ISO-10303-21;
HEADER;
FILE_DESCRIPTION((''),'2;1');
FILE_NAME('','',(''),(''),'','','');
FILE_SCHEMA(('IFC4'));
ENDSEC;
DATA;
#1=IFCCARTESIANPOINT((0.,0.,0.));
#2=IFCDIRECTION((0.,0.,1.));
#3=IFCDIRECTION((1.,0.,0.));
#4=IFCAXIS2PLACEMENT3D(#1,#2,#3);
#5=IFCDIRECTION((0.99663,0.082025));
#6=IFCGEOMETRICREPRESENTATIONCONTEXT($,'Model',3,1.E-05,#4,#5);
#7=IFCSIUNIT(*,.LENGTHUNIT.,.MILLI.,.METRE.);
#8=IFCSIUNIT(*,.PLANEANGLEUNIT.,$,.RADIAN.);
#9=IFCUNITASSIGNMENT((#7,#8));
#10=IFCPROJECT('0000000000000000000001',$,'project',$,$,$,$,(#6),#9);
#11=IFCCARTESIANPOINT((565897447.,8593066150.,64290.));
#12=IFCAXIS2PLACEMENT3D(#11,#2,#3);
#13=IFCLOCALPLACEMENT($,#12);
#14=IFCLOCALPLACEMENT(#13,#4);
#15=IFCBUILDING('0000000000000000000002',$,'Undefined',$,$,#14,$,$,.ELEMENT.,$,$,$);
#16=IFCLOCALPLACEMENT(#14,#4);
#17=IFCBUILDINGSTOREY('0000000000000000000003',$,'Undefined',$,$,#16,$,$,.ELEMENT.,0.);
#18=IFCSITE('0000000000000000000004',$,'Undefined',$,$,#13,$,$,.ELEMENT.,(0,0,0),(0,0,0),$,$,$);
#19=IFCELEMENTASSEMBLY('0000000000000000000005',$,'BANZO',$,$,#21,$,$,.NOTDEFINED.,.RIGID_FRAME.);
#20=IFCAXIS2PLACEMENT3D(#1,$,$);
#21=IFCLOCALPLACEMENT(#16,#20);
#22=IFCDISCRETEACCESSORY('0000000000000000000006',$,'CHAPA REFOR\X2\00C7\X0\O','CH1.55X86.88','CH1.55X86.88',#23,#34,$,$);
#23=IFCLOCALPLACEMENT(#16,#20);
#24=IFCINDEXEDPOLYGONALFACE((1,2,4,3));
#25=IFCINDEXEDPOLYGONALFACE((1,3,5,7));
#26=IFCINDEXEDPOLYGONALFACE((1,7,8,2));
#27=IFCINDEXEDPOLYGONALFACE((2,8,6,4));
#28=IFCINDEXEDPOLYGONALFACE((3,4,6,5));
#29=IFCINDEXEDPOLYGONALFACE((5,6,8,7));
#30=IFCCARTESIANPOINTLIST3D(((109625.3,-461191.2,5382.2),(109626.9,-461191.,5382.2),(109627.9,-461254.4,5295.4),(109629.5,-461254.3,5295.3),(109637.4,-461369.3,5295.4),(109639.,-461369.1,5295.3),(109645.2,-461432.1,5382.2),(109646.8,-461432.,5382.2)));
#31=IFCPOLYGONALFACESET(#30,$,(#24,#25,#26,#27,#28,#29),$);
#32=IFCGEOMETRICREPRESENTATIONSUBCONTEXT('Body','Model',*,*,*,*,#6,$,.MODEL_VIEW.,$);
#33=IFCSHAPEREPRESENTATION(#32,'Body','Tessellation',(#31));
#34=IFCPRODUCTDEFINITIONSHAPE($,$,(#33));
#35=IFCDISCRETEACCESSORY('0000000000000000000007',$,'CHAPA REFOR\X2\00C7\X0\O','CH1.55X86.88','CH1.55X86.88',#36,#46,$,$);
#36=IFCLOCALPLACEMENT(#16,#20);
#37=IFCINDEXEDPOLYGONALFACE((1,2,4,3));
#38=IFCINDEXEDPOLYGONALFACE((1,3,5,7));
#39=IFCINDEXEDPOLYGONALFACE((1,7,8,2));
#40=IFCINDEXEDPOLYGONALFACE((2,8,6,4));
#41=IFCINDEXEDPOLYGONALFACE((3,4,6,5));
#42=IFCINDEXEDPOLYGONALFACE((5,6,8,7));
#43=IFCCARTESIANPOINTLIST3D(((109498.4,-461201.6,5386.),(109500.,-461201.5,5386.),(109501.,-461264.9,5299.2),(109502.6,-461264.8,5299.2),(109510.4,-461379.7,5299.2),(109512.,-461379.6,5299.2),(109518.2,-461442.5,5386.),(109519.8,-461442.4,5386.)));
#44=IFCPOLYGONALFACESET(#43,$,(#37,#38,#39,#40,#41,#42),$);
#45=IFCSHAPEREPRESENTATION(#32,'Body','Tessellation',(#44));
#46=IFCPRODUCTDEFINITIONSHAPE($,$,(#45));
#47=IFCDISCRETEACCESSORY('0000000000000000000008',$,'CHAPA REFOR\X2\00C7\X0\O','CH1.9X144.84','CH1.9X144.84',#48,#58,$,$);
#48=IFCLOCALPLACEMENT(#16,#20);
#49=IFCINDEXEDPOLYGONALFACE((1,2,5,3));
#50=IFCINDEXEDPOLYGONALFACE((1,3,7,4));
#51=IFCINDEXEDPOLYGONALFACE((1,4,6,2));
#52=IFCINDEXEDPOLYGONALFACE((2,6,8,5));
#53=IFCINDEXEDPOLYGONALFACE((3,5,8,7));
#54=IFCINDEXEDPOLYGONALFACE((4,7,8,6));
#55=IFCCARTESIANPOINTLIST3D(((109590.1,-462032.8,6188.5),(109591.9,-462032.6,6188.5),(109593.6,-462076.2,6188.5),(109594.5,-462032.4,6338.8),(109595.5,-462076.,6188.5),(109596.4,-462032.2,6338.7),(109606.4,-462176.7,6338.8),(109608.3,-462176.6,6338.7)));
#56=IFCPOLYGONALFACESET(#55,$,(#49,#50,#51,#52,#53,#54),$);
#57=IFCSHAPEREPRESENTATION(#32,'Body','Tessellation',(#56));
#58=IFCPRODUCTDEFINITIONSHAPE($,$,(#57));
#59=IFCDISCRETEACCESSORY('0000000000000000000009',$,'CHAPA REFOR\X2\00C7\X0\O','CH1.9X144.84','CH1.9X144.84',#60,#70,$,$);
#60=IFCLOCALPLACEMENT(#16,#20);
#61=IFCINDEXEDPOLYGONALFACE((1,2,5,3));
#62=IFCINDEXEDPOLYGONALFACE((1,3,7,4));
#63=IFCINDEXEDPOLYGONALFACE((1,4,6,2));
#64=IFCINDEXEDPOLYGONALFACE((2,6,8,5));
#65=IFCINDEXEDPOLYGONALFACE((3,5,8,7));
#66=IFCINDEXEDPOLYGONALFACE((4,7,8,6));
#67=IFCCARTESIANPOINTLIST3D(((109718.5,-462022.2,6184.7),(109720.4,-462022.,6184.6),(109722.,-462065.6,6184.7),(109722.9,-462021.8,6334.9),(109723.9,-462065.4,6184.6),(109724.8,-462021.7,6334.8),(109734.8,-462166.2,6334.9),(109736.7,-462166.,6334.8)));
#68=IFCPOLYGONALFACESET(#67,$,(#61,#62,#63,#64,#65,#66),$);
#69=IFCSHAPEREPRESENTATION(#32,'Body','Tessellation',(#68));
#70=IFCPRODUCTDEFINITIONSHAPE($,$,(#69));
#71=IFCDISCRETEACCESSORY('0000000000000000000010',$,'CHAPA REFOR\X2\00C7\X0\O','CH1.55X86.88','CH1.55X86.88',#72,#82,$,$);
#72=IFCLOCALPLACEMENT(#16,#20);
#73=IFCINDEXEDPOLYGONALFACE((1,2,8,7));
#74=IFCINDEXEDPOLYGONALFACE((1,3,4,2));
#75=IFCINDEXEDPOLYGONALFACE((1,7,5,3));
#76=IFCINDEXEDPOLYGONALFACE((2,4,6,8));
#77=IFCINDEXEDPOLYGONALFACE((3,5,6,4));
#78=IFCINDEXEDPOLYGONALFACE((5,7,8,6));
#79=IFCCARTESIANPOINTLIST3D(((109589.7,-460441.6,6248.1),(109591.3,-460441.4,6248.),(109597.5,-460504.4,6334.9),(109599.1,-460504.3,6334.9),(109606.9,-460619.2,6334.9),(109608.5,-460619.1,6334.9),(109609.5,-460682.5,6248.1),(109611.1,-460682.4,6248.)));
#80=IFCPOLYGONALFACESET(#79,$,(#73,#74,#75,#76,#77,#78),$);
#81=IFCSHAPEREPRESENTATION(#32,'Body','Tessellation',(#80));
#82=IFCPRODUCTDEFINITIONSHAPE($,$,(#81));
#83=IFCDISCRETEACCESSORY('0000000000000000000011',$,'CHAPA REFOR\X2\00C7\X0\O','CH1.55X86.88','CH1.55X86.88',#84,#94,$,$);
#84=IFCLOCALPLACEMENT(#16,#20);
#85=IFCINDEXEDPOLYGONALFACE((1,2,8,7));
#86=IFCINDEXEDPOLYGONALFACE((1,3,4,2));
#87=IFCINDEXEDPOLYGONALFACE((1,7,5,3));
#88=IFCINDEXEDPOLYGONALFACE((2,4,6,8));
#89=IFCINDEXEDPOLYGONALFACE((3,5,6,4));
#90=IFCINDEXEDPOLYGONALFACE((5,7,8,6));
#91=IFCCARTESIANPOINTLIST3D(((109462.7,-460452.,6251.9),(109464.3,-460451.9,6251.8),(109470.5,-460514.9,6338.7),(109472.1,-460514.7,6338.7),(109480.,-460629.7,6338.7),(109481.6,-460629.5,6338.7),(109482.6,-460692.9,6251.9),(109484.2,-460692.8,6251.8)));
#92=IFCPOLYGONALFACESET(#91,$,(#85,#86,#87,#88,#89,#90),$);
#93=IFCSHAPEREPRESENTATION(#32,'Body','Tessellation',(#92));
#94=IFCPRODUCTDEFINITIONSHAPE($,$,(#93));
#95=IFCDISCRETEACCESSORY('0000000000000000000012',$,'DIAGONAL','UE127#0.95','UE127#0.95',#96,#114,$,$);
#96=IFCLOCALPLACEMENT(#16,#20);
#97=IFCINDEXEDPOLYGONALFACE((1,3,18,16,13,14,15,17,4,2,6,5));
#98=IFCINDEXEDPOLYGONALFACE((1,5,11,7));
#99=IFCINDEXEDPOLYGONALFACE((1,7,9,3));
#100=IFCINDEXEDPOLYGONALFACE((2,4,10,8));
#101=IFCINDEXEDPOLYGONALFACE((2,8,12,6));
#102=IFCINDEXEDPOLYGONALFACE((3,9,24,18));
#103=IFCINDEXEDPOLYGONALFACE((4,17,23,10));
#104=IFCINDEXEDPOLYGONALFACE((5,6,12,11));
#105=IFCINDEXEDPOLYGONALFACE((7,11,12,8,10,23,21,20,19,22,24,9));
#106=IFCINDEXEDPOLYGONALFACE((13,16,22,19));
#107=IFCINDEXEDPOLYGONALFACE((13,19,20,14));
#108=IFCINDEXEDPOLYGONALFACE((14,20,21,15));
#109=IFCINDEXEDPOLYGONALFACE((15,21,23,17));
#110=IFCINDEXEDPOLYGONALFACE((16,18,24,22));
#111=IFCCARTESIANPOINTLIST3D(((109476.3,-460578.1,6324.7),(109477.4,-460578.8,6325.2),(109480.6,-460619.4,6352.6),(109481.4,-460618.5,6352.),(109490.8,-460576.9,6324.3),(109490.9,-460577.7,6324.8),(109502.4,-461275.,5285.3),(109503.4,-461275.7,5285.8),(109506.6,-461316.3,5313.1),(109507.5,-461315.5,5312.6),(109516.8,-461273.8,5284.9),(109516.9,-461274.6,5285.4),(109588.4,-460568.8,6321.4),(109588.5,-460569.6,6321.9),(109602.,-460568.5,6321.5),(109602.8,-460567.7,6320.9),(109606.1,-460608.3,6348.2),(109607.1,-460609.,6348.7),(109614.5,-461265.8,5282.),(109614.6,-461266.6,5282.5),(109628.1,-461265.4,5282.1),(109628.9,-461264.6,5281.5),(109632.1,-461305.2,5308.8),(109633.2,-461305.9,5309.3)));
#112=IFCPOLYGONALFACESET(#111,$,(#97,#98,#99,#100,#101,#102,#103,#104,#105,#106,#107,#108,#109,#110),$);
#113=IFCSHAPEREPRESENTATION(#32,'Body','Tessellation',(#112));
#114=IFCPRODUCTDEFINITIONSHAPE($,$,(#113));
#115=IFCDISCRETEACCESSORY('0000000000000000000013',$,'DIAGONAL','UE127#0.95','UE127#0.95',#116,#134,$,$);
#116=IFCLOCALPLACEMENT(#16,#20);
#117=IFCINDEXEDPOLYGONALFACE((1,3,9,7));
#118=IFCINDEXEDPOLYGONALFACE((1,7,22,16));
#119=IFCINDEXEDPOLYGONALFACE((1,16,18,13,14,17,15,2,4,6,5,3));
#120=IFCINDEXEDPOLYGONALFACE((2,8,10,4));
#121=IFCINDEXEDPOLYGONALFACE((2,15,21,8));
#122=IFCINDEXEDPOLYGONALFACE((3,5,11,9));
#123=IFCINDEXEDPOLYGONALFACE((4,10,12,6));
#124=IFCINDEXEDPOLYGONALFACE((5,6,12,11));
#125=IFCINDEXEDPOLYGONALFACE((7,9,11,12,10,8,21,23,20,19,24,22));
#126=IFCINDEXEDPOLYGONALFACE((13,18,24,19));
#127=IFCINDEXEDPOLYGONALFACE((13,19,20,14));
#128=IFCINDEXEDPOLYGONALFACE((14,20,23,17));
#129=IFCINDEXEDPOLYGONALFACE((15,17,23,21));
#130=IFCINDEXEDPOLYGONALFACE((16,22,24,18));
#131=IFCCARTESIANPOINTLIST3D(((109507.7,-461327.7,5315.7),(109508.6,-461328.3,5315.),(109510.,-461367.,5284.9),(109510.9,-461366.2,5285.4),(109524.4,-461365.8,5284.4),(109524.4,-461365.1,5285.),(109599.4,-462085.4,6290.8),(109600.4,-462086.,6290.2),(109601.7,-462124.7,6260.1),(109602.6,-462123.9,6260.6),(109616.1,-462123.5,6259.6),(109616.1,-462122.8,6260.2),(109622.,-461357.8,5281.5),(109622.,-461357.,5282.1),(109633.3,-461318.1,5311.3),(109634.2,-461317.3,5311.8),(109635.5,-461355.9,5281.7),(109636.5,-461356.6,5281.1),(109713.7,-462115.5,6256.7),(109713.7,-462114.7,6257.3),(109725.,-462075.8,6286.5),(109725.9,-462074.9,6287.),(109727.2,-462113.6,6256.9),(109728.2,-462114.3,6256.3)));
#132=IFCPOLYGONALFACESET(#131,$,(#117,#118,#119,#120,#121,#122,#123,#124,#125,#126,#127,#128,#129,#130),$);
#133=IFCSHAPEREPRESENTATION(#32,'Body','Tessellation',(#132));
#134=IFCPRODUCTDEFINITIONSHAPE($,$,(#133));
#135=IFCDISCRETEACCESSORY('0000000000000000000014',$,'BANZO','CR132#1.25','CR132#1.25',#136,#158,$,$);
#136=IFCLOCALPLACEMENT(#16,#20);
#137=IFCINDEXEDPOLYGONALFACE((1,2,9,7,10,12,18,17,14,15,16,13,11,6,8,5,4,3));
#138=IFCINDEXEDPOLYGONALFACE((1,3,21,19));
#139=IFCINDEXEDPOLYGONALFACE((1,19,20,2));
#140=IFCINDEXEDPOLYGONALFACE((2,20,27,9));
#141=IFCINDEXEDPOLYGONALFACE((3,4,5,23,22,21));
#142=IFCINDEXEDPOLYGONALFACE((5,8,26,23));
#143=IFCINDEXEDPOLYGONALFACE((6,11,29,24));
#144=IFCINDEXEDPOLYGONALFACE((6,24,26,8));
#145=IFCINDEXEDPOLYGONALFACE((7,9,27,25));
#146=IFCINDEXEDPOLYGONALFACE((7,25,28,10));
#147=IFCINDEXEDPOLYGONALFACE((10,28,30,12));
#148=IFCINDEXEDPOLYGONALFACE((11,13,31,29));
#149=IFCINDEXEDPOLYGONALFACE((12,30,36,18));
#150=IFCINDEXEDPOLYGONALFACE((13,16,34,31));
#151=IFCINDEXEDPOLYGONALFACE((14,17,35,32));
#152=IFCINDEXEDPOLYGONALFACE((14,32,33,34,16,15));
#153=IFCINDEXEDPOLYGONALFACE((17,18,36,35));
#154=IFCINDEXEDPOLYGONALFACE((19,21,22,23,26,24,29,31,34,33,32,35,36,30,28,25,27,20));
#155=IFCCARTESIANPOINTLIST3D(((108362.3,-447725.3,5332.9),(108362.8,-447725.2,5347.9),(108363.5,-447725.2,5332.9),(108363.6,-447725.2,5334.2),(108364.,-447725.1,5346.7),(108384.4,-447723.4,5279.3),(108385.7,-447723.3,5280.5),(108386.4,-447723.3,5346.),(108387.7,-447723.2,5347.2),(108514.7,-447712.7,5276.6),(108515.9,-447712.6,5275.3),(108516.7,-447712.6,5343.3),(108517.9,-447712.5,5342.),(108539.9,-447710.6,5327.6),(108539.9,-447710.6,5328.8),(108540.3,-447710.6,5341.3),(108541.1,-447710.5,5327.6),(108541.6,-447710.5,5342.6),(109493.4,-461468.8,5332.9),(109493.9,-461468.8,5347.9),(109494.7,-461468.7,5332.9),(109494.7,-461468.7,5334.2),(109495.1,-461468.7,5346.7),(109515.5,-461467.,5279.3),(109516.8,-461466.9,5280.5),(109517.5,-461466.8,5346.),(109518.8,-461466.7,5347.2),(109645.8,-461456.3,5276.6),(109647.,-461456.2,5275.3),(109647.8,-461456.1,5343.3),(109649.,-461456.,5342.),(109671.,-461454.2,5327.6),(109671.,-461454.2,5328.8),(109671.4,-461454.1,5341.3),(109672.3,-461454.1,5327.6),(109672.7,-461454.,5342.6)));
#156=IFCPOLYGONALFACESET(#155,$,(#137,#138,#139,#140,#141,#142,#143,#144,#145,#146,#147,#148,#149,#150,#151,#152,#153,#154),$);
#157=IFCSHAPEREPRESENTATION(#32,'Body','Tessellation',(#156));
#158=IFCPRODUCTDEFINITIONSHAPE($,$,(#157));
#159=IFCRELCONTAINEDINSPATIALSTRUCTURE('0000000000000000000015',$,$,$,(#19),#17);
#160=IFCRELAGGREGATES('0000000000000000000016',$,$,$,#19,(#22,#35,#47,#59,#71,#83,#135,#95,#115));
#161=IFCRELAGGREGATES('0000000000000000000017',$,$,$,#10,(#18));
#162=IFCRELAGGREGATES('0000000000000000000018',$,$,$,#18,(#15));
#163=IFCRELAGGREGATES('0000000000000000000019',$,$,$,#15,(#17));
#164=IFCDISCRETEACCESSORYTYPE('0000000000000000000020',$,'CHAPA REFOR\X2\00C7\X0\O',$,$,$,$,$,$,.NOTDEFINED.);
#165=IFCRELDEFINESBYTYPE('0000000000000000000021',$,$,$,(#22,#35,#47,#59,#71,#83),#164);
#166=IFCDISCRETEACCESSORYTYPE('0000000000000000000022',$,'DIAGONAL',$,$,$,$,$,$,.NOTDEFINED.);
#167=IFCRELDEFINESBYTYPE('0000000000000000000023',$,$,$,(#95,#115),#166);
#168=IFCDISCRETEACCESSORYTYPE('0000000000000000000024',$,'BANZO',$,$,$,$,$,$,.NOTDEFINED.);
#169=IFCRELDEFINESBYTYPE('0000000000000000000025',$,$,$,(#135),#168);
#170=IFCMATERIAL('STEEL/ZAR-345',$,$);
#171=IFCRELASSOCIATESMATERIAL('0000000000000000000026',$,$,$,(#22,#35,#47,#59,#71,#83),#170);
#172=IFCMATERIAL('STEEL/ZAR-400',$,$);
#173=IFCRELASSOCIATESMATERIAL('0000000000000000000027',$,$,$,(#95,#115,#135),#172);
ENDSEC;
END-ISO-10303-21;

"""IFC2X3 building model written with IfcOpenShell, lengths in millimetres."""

from ifc_helpers import new_model, si_unit, direction, frame, frame_2d, origin_with_axes, place, context, subcontext, project, spatial, polyline, c_section, outline, extrude, material, type_object, element, aggregate, save


model = new_model("IFC2X3")

# Units and contexts
model_context = context("Model", 3, precision=1e-05, world=origin_with_axes(), true_north=direction((0.99663, 0.082025)))
body_context = subcontext(model_context, "Body", "Model", "MODEL_VIEW")
ifc_project = project(units=[si_unit("LENGTHUNIT", "METRE", prefix="MILLI"), si_unit("PLANEANGLEUNIT", "RADIAN")], contexts=[model_context])

# Site, building, storey
site_placement = place(None, frame((565897447.0, 8593066150.0, 64290.0), z_axis=(0.0, 0.0, 1.0), x_axis=(1.0, 0.0, 0.0)))
site = spatial("IfcSite", under=ifc_project, at=site_placement, Name="Undefined", CompositionType="ELEMENT", RefLatitude=(0, 0, 0), RefLongitude=(0, 0, 0))
building_placement = place(site_placement, origin_with_axes())
building = spatial("IfcBuilding", under=site, at=building_placement, Name="Undefined", CompositionType="ELEMENT")
storey_placement = place(building_placement, origin_with_axes())
storey = spatial("IfcBuildingStorey", under=building, at=storey_placement, Name="Undefined", CompositionType="ELEMENT", Elevation=0.0)

# Shared definitions
ifc_material_1 = material(Name="STEEL/ZAR-400")

# Element assembly, discrete accessories
assembly_1_placement = place(storey_placement, origin_with_axes())
assembly_1 = element("IfcElementAssembly", 1, at=assembly_1_placement, inside=storey, Name="BANZO", AssemblyPlace="NOTDEFINED", PredefinedType="RIGID_FRAME")
ifc_material_2 = material(Name="STEEL/ZAR-345")
discrete_accessory_type_1 = type_object("IfcDiscreteAccessoryType", Name="CHAPA REFORÇO")
discrete_accessory_1_placement = place(assembly_1_placement, frame((109626.1, -461191.1, 5382.2), z_axis=(0.996182, 0.081989, -0.029987), x_axis=(0.082025, -0.99663, 0.0)))
discrete_accessory_1 = element("IfcDiscreteAccessory", 2, at=discrete_accessory_1_placement, type_object=discrete_accessory_type_1, material=ifc_material_2, Name="CHAPA REFORÇO", Description="CH1.55X86.88", ObjectType="CH1.55X86.88", context=body_context, shape_type="SweptSolid", body=[
    extrude(outline(polyline([(0.0, 0.0), (241.7, 0.0), (178.5, 86.9), (63.3, 86.9), (0.0, 0.0)])), frame((0.0, 0.0, -0.8), z_axis=(0.0, 0.0, 1.0), x_axis=(1.0, 0.0, 0.0)), (0.0, 0.0, 1.0), 1.6),
])
discrete_accessory_2_placement = place(assembly_1_placement, frame((109499.2, -461201.6, 5386.0), z_axis=(0.996182, 0.081989, -0.029987), x_axis=(0.082025, -0.99663, 0.0)))
discrete_accessory_2 = element("IfcDiscreteAccessory", 3, at=discrete_accessory_2_placement, type_object=discrete_accessory_type_1, material=ifc_material_2, Name="CHAPA REFORÇO", Description="CH1.55X86.88", ObjectType="CH1.55X86.88", context=body_context, shape_type="SweptSolid", body=[
    extrude(outline(polyline([(0.0, 0.0), (241.7, 0.0), (178.5, 86.9), (63.3, 86.9), (0.0, 0.0)])), frame((0.0, 0.0, -0.8), z_axis=(0.0, 0.0, 1.0), x_axis=(1.0, 0.0, 0.0)), (0.0, 0.0, 1.0), 1.6),
])
discrete_accessory_3_placement = place(assembly_1_placement, frame((109595.5, -462032.3, 6338.7), z_axis=(0.996182, 0.081989, -0.029987), x_axis=(0.082025, -0.99663, 0.0)))
discrete_accessory_3 = element("IfcDiscreteAccessory", 4, at=discrete_accessory_3_placement, type_object=discrete_accessory_type_1, material=ifc_material_2, Name="CHAPA REFORÇO", Description="CH1.9X144.84", ObjectType="CH1.9X144.84", context=body_context, shape_type="SweptSolid", body=[
    extrude(outline(polyline([(0.0, 0.0), (144.8, 0.0), (43.5, 150.3), (0.0, 150.3), (0.0, 0.0)])), frame((0.0, 0.0, -0.9), z_axis=(0.0, 0.0, 1.0), x_axis=(1.0, 0.0, 0.0)), (0.0, 0.0, 1.0), 1.9),
])
discrete_accessory_4_placement = place(assembly_1_placement, frame((109723.9, -462021.8, 6334.9), z_axis=(0.996182, 0.081989, -0.029987), x_axis=(0.082025, -0.99663, 0.0)))
discrete_accessory_4 = element("IfcDiscreteAccessory", 5, at=discrete_accessory_4_placement, type_object=discrete_accessory_type_1, material=ifc_material_2, Name="CHAPA REFORÇO", Description="CH1.9X144.84", ObjectType="CH1.9X144.84", context=body_context, shape_type="SweptSolid", body=[
    extrude(outline(polyline([(0.0, 0.0), (144.8, 0.0), (43.5, 150.3), (0.0, 150.3), (0.0, 0.0)])), frame((0.0, 0.0, -0.9), z_axis=(0.0, 0.0, 1.0), x_axis=(1.0, 0.0, 0.0)), (0.0, 0.0, 1.0), 1.9),
])
discrete_accessory_5_placement = place(assembly_1_placement, frame((109610.3, -460682.4, 6248.0), z_axis=(0.996182, 0.081989, -0.029987), x_axis=(-0.082025, 0.99663, 0.0)))
discrete_accessory_5 = element("IfcDiscreteAccessory", 6, at=discrete_accessory_5_placement, type_object=discrete_accessory_type_1, material=ifc_material_2, Name="CHAPA REFORÇO", Description="CH1.55X86.88", ObjectType="CH1.55X86.88", context=body_context, shape_type="SweptSolid", body=[
    extrude(outline(polyline([(0.0, 0.0), (241.7, 0.0), (178.5, 86.9), (63.3, 86.9), (0.0, 0.0)])), frame((0.0, 0.0, -0.8), z_axis=(0.0, 0.0, 1.0), x_axis=(1.0, 0.0, 0.0)), (0.0, 0.0, 1.0), 1.6),
])
discrete_accessory_6_placement = place(assembly_1_placement, frame((109483.4, -460692.9, 6251.9), z_axis=(0.996182, 0.081989, -0.029987), x_axis=(-0.082025, 0.99663, 0.0)))
discrete_accessory_6 = element("IfcDiscreteAccessory", 7, at=discrete_accessory_6_placement, type_object=discrete_accessory_type_1, material=ifc_material_2, Name="CHAPA REFORÇO", Description="CH1.55X86.88", ObjectType="CH1.55X86.88", context=body_context, shape_type="SweptSolid", body=[
    extrude(outline(polyline([(0.0, 0.0), (241.7, 0.0), (178.5, 86.9), (63.3, 86.9), (0.0, 0.0)])), frame((0.0, 0.0, -0.8), z_axis=(0.0, 0.0, 1.0), x_axis=(1.0, 0.0, 0.0)), (0.0, 0.0, 1.0), 1.6),
])
discrete_accessory_type_2 = type_object("IfcDiscreteAccessoryType", Name="DIAGONAL")
discrete_accessory_7_placement = place(assembly_1_placement, frame((109541.7, -460593.5, 6336.7), z_axis=(-0.996182, -0.081989, 0.029987), x_axis=(0.020829, -0.556784, -0.830396)))
discrete_accessory_7 = element("IfcDiscreteAccessory", 8, at=discrete_accessory_7_placement, type_object=discrete_accessory_type_2, material=ifc_material_1, Name="DIAGONAL", Description="UE127#0.95", ObjectType="UE127#0.95", context=body_context, shape_type="SweptSolid", body=[
    extrude(c_section(Depth=127.0, Width=50.0, WallThickness=0.9, Girth=14.5, at=frame_2d((0.0, 0.0), x_axis=(1.0, 0.0))), frame((1251.7, 0.0, 0.0), z_axis=(-1.0, 0.0, 0.0), x_axis=(0.0, -1.0, 0.0)), (0.0, 0.0, 1.0), 1251.7),
])
discrete_accessory_8_placement = place(assembly_1_placement, frame((109572.1, -461342.1, 5298.4), z_axis=(-0.996182, -0.081989, 0.029987), x_axis=(0.074062, -0.611853, 0.787496)))
discrete_accessory_8 = element("IfcDiscreteAccessory", 9, at=discrete_accessory_8_placement, type_object=discrete_accessory_type_2, material=ifc_material_1, Name="DIAGONAL", Description="UE127#0.95", ObjectType="UE127#0.95", context=body_context, shape_type="SweptSolid", body=[
    extrude(c_section(Depth=127.0, Width=50.0, WallThickness=0.9, Girth=14.5, at=frame_2d((0.0, 0.0), x_axis=(1.0, 0.0))), frame((1238.3, 0.0, 0.0), z_axis=(-1.0, 0.0, 0.0), x_axis=(0.0, -1.0, 0.0)), (0.0, 0.0, 1.0), 1238.3),
])
discrete_accessory_type_3 = type_object("IfcDiscreteAccessoryType", Name="BANZO")
discrete_accessory_9_placement = place(assembly_1_placement, frame((109582.3, -461461.5, 5311.3), z_axis=(-0.029886, -0.00246, -0.99955), x_axis=(-0.082025, 0.99663, 0.0)))
discrete_accessory_9 = element("IfcDiscreteAccessory", 10, at=discrete_accessory_9_placement, type_object=discrete_accessory_type_3, material=ifc_material_1, Name="BANZO", Description="CR132#1.25", ObjectType="CR132#1.25", context=body_context, shape_type="SweptSolid", body=[
    extrude(outline(polyline([(-64.7, 32.7), (-64.7, -34.0), (-89.7, -34.0), (-89.7, -19.0), (-88.5, -19.0), (-88.5, -20.3), (-88.5, -32.8), (-66.0, -32.8), (-66.0, 34.0), (66.0, 34.0), (66.0, -32.7), (88.5, -32.7), (88.5, -20.2), (88.5, -19.0), (89.7, -19.0), (89.7, -34.0), (64.7, -34.0), (64.7, 32.8), (-64.7, 32.7)])), frame((13790.0, 0.0, 0.0), z_axis=(-1.0, 0.0, 0.0), x_axis=(0.0, -1.0, 0.0)), (0.0, 0.0, 1.0), 13790.0),
])
aggregate(assembly_1, [discrete_accessory_1, discrete_accessory_2, discrete_accessory_3, discrete_accessory_4, discrete_accessory_5, discrete_accessory_6, discrete_accessory_9, discrete_accessory_7, discrete_accessory_8])

save(model, "model.ifc")
